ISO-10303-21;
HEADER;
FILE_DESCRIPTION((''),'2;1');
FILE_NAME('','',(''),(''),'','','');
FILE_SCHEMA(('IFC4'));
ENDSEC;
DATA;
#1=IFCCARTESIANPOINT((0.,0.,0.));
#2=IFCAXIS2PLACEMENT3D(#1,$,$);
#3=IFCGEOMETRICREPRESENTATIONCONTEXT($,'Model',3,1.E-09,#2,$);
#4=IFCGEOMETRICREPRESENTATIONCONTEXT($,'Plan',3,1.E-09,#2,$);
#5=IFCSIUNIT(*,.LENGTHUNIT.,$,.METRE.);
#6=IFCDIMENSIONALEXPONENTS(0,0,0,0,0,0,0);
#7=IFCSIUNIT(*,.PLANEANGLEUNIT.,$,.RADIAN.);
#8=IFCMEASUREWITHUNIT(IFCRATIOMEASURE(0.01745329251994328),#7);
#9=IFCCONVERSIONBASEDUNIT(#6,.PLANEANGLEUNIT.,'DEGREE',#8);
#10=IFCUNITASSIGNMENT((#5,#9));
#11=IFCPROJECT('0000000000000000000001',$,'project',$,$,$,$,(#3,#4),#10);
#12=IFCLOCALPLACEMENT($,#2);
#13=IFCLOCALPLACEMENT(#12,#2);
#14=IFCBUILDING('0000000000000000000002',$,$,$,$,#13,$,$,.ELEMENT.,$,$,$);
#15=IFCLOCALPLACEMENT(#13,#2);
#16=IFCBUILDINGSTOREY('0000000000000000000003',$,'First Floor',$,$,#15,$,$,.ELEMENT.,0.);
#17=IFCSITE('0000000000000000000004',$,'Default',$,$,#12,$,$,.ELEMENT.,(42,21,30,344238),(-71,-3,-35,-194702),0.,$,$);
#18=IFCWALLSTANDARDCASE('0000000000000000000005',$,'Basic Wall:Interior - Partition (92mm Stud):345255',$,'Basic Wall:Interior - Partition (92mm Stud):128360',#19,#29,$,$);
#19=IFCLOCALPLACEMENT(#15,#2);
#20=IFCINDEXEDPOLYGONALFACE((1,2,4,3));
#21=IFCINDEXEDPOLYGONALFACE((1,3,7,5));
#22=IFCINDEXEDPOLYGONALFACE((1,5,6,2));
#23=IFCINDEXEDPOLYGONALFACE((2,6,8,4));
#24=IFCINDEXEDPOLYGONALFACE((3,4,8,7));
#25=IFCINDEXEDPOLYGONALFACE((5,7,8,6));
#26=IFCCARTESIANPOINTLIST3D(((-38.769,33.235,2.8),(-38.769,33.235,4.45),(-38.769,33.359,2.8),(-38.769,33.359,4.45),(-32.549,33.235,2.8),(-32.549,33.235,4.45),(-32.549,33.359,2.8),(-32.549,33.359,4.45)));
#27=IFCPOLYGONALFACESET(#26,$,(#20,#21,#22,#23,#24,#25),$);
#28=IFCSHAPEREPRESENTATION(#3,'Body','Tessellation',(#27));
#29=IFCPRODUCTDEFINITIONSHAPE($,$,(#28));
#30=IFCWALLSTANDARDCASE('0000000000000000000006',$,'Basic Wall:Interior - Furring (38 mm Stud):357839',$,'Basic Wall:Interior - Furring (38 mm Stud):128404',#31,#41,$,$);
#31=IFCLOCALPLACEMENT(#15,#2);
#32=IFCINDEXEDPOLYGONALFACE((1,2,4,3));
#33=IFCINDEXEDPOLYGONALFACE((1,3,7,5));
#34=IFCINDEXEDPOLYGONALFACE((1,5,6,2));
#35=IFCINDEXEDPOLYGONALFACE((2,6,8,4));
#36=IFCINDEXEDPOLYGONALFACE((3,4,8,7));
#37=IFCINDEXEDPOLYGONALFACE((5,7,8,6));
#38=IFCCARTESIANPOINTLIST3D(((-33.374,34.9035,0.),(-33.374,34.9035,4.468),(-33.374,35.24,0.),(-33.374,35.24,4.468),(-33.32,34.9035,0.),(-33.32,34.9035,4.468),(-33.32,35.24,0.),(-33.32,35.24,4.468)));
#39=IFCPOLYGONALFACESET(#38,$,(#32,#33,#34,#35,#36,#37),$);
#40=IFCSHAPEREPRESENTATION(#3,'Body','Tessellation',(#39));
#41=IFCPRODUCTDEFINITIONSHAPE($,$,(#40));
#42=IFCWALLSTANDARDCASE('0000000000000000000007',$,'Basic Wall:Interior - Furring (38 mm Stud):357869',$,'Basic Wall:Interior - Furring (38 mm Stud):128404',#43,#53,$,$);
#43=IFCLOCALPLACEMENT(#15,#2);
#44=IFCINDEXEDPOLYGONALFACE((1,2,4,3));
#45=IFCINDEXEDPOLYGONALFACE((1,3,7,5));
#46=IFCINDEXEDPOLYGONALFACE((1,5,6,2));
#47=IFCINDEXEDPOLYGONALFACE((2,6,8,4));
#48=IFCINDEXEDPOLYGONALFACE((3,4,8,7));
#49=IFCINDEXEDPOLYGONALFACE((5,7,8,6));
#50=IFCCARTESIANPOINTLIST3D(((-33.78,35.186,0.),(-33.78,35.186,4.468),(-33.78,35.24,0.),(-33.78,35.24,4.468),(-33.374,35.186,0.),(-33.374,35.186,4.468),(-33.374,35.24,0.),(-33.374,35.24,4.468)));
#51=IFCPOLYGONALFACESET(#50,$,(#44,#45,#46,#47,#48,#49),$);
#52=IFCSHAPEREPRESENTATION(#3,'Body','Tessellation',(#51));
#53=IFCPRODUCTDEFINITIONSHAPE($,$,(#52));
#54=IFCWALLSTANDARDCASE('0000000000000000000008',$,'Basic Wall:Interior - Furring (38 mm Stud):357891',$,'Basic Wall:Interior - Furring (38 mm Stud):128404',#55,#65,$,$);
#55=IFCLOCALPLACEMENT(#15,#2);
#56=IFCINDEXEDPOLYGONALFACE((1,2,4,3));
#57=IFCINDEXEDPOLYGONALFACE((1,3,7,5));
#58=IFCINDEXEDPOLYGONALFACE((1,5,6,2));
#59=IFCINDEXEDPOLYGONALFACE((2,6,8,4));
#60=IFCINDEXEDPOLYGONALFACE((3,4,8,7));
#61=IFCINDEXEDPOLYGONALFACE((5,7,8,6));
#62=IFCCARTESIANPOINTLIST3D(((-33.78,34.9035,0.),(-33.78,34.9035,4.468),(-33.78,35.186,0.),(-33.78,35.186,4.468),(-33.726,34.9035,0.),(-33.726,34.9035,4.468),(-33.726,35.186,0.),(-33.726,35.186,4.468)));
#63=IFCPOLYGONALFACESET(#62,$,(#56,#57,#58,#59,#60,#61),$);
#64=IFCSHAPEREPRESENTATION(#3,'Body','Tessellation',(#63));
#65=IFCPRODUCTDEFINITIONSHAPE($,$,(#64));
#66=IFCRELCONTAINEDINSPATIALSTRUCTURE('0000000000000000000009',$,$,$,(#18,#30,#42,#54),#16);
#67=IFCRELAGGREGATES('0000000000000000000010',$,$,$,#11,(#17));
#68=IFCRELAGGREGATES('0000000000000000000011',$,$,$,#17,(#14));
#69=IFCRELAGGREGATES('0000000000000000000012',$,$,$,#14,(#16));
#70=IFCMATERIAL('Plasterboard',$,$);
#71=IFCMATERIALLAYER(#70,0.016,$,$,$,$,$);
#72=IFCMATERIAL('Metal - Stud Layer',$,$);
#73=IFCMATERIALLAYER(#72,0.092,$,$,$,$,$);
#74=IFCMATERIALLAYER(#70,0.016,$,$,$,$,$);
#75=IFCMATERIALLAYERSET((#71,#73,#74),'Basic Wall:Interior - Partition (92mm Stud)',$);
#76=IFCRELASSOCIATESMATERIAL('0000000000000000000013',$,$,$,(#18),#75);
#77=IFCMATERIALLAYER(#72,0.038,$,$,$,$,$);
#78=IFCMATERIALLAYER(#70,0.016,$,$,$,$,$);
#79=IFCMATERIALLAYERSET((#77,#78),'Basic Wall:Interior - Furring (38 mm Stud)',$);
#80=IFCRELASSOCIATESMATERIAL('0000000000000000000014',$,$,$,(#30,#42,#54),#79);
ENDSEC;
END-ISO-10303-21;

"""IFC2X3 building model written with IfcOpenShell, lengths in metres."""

from ifc_helpers import new_model, entity, si_unit, converted_unit, frame, frame_2d, origin, place, context, project, spatial, rectangle, extrude, material, layer, layer_set, layer_usage, element, save


model = new_model("IFC2X3")

# Units and contexts
model_context = context("Model", 3, precision=1e-09, world=origin())
plan_context = context("Plan", 3, precision=1e-09, world=origin())
ifc_project = project(units=[si_unit("LENGTHUNIT", "METRE"), converted_unit("PLANEANGLEUNIT", "DEGREE", entity("IfcRatioMeasure", 0.01745329251994328), si_unit("PLANEANGLEUNIT", "RADIAN"), dimensions=[0, 0, 0, 0, 0, 0, 0])], contexts=[model_context, plan_context])

# Site, building, storey
site_placement = place(None, origin())
site = spatial("IfcSite", under=ifc_project, at=site_placement, Name="Default", CompositionType="ELEMENT", RefLatitude=(42, 21, 30, 344238), RefLongitude=(-71, -3, -35, -194702), RefElevation=0.0)
building_placement = place(site_placement, origin())
building = spatial("IfcBuilding", under=site, at=building_placement, CompositionType="ELEMENT")
storey_placement = place(building_placement, origin())
storey = spatial("IfcBuildingStorey", under=building, at=storey_placement, Name="First Floor", CompositionType="ELEMENT", Elevation=0.0)

# Shared definitions
ifc_material_1 = material(Name="Plasterboard")
ifc_layer_1 = layer(ifc_material_1, 0.016)
ifc_material_2 = material(Name="Metal - Stud Layer")
ifc_layer_2 = layer(ifc_material_2, 0.092)
ifc_layer_3 = layer(ifc_material_1, 0.016)
ifc_layer_set_1 = layer_set([ifc_layer_1, ifc_layer_2, ifc_layer_3], Name="Basic Wall:Interior - Partition (92mm Stud)")

# Walls
ifc_layer_usage_1 = layer_usage(ifc_layer_set_1, "AXIS2", "NEGATIVE", 0.062)
wall_1_placement = place(storey_placement, frame((-32.549, 33.297, 2.8), z_axis=(0.0, 0.0, 1.0), x_axis=(-1.0, 0.0, 0.0)))
element("IfcWallStandardCase", 1, at=wall_1_placement, inside=storey, material=ifc_layer_usage_1, Name="Basic Wall:Interior - Partition (92mm Stud):345255", ObjectType="Basic Wall:Interior - Partition (92mm Stud):128360", context=model_context, shape_type="SweptSolid", body=[
    extrude(rectangle(XDim=6.22, YDim=0.124, at=frame_2d((3.11, 0.0), x_axis=(-1.0, 0.0))), origin(), (0.0, 0.0, 1.0), 1.65),
])
ifc_layer_4 = layer(ifc_material_2, 0.038)
ifc_layer_5 = layer(ifc_material_1, 0.016)
ifc_layer_set_2 = layer_set([ifc_layer_4, ifc_layer_5], Name="Basic Wall:Interior - Furring (38 mm Stud)")
ifc_layer_usage_2 = layer_usage(ifc_layer_set_2, "AXIS2", "NEGATIVE", 0.027)
wall_2_placement = place(storey_placement, frame((-33.347, 34.9035, 0.0), z_axis=(0.0, 0.0, 1.0), x_axis=(0.0, 1.0, 0.0)))
element("IfcWallStandardCase", 2, at=wall_2_placement, inside=storey, material=ifc_layer_usage_2, Name="Basic Wall:Interior - Furring (38 mm Stud):357839", ObjectType="Basic Wall:Interior - Furring (38 mm Stud):128404", context=model_context, shape_type="SweptSolid", body=[
    extrude(rectangle(XDim=0.3365, YDim=0.054, at=frame_2d((0.1682, 0.0), x_axis=(-1.0, 0.0))), origin(), (0.0, 0.0, 1.0), 4.468),
])
ifc_layer_usage_3 = layer_usage(ifc_layer_set_2, "AXIS2", "NEGATIVE", 0.027)
wall_3_placement = place(storey_placement, frame((-33.374, 35.213, 0.0), z_axis=(0.0, 0.0, 1.0), x_axis=(-1.0, 0.0, 0.0)))
element("IfcWallStandardCase", 3, at=wall_3_placement, inside=storey, material=ifc_layer_usage_3, Name="Basic Wall:Interior - Furring (38 mm Stud):357869", ObjectType="Basic Wall:Interior - Furring (38 mm Stud):128404", context=model_context, shape_type="SweptSolid", body=[
    extrude(rectangle(XDim=0.406, YDim=0.054, at=frame_2d((0.203, 0.0), x_axis=(-1.0, 0.0))), origin(), (0.0, 0.0, 1.0), 4.468),
])
ifc_layer_usage_4 = layer_usage(ifc_layer_set_2, "AXIS2", "NEGATIVE", 0.027)
wall_4_placement = place(storey_placement, frame((-33.753, 35.186, 0.0), z_axis=(0.0, 0.0, 1.0), x_axis=(0.0, -1.0, 0.0)))
element("IfcWallStandardCase", 4, at=wall_4_placement, inside=storey, material=ifc_layer_usage_4, Name="Basic Wall:Interior - Furring (38 mm Stud):357891", ObjectType="Basic Wall:Interior - Furring (38 mm Stud):128404", context=model_context, shape_type="SweptSolid", body=[
    extrude(rectangle(XDim=0.2825, YDim=0.054, at=frame_2d((0.1412, 0.0), x_axis=(-1.0, 0.0))), origin(), (0.0, 0.0, 1.0), 4.468),
])

save(model, "model.ifc")
